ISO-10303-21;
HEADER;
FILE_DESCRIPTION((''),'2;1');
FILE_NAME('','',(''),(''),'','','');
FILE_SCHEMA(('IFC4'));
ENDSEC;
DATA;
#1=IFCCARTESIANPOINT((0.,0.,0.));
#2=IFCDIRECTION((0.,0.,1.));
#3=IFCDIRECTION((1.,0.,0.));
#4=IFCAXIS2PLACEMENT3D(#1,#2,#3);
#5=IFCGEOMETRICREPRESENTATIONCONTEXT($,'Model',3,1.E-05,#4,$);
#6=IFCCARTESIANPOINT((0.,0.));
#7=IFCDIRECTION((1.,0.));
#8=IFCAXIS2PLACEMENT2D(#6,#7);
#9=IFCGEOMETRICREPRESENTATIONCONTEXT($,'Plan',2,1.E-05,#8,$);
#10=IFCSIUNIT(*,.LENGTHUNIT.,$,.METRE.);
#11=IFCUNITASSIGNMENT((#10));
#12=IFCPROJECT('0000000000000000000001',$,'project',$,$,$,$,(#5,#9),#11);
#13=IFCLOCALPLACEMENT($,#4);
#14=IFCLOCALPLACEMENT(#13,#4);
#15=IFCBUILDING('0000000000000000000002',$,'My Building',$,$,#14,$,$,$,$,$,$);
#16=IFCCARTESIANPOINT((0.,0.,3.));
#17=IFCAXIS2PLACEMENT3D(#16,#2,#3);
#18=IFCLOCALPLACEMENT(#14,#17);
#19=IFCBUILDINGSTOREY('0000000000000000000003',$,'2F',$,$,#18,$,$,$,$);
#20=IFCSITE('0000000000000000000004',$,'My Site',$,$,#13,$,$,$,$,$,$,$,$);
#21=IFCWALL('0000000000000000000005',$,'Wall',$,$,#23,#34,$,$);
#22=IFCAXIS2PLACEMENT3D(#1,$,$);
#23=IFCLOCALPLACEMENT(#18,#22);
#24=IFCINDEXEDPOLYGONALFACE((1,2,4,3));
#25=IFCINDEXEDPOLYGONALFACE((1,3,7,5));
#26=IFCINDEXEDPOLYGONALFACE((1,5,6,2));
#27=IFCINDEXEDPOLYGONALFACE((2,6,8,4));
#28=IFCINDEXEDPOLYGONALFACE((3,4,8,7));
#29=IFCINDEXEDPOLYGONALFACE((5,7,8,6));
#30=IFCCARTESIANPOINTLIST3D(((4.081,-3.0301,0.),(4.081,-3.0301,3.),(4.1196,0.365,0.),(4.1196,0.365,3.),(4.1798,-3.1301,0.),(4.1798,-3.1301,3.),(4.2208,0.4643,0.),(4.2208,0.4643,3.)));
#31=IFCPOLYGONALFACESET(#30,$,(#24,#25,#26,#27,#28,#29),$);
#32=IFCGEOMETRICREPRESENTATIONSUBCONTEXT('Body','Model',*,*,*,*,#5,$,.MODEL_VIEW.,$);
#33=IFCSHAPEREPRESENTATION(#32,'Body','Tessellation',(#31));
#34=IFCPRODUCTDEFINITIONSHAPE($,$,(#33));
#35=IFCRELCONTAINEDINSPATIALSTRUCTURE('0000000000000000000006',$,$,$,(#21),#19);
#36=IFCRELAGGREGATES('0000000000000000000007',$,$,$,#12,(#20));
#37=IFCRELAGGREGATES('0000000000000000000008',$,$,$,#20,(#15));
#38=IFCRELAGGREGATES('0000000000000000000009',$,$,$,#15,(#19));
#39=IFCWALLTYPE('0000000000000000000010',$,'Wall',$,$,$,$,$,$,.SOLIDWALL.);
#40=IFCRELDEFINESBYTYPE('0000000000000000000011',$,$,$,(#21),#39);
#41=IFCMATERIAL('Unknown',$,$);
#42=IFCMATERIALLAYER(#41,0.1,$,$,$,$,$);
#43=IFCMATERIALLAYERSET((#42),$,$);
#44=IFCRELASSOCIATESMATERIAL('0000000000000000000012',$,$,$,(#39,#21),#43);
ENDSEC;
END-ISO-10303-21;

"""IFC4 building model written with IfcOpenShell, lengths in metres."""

from ifc_helpers import new_model, si_unit, frame, origin_with_axes, origin_2d_with_axis, place, context, subcontext, project, spatial, line, indexed_curve, outline, extrude, material, layer, layer_set, layer_usage, type_object, element, save


model = new_model("IFC4")

# Units and contexts
model_context = context("Model", 3, precision=1e-05, world=origin_with_axes())
plan_context = context("Plan", 2, precision=1e-05, world=origin_2d_with_axis())
body_context_1 = subcontext(model_context, "Body", "Model", "MODEL_VIEW")
ifc_project = project(units=[si_unit("LENGTHUNIT", "METRE")], contexts=[model_context, plan_context])

# Site, building, storey
site_placement = place(None, origin_with_axes())
site = spatial("IfcSite", under=ifc_project, at=site_placement, Name="My Site")
building_placement = place(site_placement, origin_with_axes())
building = spatial("IfcBuilding", under=site, at=building_placement, Name="My Building")
storey_placement = place(building_placement, frame((0.0, 0.0, 3.0), z_axis=(0.0, 0.0, 1.0), x_axis=(1.0, 0.0, 0.0)))
storey = spatial("IfcBuildingStorey", under=building, at=storey_placement, Name="2F")

# Shared definitions
ifc_material = material(Name="Unknown")

# Shared definitions
ifc_layer = layer(ifc_material, 0.1)
ifc_layer_set = layer_set([ifc_layer])
wall_type = type_object("IfcWallType", Name="Wall", PredefinedType="SOLIDWALL", material=ifc_layer_set)

# Wall
ifc_layer_usage_1 = layer_usage(ifc_layer_set, "AXIS2", "POSITIVE", 0.0)
wall_1_placement = place(storey_placement, frame((4.1196, 0.365, 0.0), z_axis=(0.0, 0.0, 1.0), x_axis=(-0.011386, -0.999935, 0.0)))
element("IfcWall", 1, at=wall_1_placement, inside=storey, type_object=wall_type, material=ifc_layer_usage_1, Name="Wall", context=body_context_1, shape_type="SweptSolid", body=[
    extrude(outline(indexed_curve([(0.0, 0.0), (-0.1004, 0.1), (3.4942, 0.1), (3.3954, 0.0)], segments=[line(1, 2, 3, 4, 1)])), origin_with_axes(), (0.0, 0.0, 1.0), 3.0),
])

save(model, "model.ifc")
